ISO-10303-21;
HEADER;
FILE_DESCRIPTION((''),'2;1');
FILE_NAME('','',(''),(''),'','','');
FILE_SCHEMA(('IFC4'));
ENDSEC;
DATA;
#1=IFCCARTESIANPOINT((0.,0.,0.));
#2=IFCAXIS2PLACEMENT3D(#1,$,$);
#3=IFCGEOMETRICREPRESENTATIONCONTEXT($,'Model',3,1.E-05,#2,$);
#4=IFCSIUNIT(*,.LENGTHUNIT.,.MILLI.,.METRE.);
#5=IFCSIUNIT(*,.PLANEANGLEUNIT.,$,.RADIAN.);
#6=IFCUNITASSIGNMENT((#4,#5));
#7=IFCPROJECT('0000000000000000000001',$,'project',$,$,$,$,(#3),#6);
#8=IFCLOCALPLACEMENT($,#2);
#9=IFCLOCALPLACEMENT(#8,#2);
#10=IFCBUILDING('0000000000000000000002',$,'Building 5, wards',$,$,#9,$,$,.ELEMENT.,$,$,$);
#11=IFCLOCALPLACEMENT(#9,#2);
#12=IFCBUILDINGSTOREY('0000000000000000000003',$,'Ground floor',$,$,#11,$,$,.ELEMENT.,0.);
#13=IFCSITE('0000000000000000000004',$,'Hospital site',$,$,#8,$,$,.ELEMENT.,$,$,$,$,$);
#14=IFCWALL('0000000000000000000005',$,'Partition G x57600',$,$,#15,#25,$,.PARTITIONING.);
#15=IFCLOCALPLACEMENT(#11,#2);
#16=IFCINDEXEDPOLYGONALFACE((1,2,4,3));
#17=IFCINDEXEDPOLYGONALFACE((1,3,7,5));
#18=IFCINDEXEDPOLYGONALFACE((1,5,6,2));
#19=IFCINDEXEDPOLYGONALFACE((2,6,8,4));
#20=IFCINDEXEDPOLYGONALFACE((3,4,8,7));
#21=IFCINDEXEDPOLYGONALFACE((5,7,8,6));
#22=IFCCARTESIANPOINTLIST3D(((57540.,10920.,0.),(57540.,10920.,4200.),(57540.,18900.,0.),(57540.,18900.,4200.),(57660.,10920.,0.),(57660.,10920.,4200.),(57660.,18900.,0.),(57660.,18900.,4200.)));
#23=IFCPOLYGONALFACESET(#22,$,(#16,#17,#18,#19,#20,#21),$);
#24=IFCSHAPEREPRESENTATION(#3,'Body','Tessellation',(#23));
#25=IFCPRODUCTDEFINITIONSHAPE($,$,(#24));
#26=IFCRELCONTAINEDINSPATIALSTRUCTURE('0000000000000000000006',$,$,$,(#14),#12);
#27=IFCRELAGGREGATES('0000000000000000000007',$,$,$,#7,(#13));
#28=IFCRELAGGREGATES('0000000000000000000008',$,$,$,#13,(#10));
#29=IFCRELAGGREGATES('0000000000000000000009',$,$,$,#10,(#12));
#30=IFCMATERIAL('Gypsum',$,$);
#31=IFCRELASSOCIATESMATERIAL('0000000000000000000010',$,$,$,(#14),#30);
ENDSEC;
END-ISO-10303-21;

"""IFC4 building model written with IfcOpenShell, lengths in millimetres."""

from ifc_helpers import new_model, si_unit, frame, frame_2d, origin, place, context, project, spatial, rectangle, extrude, material, element, save


model = new_model("IFC4")

# Units and contexts
model_context = context("Model", 3, precision=1e-05, world=origin())
ifc_project = project(units=[si_unit("LENGTHUNIT", "METRE", prefix="MILLI"), si_unit("PLANEANGLEUNIT", "RADIAN")], contexts=[model_context])

# Site, building, storey
site_placement = place(None, origin())
site = spatial("IfcSite", under=ifc_project, at=site_placement, Name="Hospital site", CompositionType="ELEMENT")
building_placement = place(site_placement, origin())
building = spatial("IfcBuilding", under=site, at=building_placement, Name="Building 5, wards", CompositionType="ELEMENT")
storey_placement = place(building_placement, origin())
storey = spatial("IfcBuildingStorey", under=building, at=storey_placement, Name="Ground floor", CompositionType="ELEMENT", Elevation=0.0)

# Wall
ifc_material = material(Name="Gypsum")
wall_placement = place(storey_placement, frame((57660.0, 10920.0, 0.0), x_axis=(0.0, 1.0, 0.0)))
element("IfcWall", 1, at=wall_placement, inside=storey, material=ifc_material, Name="Partition G x57600", PredefinedType="PARTITIONING", context=model_context, shape_type="SweptSolid", body=[
    extrude(rectangle(XDim=7980.0, YDim=120.0, at=frame_2d((3990.0, 60.0))), origin(), (0.0, 0.0, 1.0), 4200.0),
])

save(model, "model.ifc")
